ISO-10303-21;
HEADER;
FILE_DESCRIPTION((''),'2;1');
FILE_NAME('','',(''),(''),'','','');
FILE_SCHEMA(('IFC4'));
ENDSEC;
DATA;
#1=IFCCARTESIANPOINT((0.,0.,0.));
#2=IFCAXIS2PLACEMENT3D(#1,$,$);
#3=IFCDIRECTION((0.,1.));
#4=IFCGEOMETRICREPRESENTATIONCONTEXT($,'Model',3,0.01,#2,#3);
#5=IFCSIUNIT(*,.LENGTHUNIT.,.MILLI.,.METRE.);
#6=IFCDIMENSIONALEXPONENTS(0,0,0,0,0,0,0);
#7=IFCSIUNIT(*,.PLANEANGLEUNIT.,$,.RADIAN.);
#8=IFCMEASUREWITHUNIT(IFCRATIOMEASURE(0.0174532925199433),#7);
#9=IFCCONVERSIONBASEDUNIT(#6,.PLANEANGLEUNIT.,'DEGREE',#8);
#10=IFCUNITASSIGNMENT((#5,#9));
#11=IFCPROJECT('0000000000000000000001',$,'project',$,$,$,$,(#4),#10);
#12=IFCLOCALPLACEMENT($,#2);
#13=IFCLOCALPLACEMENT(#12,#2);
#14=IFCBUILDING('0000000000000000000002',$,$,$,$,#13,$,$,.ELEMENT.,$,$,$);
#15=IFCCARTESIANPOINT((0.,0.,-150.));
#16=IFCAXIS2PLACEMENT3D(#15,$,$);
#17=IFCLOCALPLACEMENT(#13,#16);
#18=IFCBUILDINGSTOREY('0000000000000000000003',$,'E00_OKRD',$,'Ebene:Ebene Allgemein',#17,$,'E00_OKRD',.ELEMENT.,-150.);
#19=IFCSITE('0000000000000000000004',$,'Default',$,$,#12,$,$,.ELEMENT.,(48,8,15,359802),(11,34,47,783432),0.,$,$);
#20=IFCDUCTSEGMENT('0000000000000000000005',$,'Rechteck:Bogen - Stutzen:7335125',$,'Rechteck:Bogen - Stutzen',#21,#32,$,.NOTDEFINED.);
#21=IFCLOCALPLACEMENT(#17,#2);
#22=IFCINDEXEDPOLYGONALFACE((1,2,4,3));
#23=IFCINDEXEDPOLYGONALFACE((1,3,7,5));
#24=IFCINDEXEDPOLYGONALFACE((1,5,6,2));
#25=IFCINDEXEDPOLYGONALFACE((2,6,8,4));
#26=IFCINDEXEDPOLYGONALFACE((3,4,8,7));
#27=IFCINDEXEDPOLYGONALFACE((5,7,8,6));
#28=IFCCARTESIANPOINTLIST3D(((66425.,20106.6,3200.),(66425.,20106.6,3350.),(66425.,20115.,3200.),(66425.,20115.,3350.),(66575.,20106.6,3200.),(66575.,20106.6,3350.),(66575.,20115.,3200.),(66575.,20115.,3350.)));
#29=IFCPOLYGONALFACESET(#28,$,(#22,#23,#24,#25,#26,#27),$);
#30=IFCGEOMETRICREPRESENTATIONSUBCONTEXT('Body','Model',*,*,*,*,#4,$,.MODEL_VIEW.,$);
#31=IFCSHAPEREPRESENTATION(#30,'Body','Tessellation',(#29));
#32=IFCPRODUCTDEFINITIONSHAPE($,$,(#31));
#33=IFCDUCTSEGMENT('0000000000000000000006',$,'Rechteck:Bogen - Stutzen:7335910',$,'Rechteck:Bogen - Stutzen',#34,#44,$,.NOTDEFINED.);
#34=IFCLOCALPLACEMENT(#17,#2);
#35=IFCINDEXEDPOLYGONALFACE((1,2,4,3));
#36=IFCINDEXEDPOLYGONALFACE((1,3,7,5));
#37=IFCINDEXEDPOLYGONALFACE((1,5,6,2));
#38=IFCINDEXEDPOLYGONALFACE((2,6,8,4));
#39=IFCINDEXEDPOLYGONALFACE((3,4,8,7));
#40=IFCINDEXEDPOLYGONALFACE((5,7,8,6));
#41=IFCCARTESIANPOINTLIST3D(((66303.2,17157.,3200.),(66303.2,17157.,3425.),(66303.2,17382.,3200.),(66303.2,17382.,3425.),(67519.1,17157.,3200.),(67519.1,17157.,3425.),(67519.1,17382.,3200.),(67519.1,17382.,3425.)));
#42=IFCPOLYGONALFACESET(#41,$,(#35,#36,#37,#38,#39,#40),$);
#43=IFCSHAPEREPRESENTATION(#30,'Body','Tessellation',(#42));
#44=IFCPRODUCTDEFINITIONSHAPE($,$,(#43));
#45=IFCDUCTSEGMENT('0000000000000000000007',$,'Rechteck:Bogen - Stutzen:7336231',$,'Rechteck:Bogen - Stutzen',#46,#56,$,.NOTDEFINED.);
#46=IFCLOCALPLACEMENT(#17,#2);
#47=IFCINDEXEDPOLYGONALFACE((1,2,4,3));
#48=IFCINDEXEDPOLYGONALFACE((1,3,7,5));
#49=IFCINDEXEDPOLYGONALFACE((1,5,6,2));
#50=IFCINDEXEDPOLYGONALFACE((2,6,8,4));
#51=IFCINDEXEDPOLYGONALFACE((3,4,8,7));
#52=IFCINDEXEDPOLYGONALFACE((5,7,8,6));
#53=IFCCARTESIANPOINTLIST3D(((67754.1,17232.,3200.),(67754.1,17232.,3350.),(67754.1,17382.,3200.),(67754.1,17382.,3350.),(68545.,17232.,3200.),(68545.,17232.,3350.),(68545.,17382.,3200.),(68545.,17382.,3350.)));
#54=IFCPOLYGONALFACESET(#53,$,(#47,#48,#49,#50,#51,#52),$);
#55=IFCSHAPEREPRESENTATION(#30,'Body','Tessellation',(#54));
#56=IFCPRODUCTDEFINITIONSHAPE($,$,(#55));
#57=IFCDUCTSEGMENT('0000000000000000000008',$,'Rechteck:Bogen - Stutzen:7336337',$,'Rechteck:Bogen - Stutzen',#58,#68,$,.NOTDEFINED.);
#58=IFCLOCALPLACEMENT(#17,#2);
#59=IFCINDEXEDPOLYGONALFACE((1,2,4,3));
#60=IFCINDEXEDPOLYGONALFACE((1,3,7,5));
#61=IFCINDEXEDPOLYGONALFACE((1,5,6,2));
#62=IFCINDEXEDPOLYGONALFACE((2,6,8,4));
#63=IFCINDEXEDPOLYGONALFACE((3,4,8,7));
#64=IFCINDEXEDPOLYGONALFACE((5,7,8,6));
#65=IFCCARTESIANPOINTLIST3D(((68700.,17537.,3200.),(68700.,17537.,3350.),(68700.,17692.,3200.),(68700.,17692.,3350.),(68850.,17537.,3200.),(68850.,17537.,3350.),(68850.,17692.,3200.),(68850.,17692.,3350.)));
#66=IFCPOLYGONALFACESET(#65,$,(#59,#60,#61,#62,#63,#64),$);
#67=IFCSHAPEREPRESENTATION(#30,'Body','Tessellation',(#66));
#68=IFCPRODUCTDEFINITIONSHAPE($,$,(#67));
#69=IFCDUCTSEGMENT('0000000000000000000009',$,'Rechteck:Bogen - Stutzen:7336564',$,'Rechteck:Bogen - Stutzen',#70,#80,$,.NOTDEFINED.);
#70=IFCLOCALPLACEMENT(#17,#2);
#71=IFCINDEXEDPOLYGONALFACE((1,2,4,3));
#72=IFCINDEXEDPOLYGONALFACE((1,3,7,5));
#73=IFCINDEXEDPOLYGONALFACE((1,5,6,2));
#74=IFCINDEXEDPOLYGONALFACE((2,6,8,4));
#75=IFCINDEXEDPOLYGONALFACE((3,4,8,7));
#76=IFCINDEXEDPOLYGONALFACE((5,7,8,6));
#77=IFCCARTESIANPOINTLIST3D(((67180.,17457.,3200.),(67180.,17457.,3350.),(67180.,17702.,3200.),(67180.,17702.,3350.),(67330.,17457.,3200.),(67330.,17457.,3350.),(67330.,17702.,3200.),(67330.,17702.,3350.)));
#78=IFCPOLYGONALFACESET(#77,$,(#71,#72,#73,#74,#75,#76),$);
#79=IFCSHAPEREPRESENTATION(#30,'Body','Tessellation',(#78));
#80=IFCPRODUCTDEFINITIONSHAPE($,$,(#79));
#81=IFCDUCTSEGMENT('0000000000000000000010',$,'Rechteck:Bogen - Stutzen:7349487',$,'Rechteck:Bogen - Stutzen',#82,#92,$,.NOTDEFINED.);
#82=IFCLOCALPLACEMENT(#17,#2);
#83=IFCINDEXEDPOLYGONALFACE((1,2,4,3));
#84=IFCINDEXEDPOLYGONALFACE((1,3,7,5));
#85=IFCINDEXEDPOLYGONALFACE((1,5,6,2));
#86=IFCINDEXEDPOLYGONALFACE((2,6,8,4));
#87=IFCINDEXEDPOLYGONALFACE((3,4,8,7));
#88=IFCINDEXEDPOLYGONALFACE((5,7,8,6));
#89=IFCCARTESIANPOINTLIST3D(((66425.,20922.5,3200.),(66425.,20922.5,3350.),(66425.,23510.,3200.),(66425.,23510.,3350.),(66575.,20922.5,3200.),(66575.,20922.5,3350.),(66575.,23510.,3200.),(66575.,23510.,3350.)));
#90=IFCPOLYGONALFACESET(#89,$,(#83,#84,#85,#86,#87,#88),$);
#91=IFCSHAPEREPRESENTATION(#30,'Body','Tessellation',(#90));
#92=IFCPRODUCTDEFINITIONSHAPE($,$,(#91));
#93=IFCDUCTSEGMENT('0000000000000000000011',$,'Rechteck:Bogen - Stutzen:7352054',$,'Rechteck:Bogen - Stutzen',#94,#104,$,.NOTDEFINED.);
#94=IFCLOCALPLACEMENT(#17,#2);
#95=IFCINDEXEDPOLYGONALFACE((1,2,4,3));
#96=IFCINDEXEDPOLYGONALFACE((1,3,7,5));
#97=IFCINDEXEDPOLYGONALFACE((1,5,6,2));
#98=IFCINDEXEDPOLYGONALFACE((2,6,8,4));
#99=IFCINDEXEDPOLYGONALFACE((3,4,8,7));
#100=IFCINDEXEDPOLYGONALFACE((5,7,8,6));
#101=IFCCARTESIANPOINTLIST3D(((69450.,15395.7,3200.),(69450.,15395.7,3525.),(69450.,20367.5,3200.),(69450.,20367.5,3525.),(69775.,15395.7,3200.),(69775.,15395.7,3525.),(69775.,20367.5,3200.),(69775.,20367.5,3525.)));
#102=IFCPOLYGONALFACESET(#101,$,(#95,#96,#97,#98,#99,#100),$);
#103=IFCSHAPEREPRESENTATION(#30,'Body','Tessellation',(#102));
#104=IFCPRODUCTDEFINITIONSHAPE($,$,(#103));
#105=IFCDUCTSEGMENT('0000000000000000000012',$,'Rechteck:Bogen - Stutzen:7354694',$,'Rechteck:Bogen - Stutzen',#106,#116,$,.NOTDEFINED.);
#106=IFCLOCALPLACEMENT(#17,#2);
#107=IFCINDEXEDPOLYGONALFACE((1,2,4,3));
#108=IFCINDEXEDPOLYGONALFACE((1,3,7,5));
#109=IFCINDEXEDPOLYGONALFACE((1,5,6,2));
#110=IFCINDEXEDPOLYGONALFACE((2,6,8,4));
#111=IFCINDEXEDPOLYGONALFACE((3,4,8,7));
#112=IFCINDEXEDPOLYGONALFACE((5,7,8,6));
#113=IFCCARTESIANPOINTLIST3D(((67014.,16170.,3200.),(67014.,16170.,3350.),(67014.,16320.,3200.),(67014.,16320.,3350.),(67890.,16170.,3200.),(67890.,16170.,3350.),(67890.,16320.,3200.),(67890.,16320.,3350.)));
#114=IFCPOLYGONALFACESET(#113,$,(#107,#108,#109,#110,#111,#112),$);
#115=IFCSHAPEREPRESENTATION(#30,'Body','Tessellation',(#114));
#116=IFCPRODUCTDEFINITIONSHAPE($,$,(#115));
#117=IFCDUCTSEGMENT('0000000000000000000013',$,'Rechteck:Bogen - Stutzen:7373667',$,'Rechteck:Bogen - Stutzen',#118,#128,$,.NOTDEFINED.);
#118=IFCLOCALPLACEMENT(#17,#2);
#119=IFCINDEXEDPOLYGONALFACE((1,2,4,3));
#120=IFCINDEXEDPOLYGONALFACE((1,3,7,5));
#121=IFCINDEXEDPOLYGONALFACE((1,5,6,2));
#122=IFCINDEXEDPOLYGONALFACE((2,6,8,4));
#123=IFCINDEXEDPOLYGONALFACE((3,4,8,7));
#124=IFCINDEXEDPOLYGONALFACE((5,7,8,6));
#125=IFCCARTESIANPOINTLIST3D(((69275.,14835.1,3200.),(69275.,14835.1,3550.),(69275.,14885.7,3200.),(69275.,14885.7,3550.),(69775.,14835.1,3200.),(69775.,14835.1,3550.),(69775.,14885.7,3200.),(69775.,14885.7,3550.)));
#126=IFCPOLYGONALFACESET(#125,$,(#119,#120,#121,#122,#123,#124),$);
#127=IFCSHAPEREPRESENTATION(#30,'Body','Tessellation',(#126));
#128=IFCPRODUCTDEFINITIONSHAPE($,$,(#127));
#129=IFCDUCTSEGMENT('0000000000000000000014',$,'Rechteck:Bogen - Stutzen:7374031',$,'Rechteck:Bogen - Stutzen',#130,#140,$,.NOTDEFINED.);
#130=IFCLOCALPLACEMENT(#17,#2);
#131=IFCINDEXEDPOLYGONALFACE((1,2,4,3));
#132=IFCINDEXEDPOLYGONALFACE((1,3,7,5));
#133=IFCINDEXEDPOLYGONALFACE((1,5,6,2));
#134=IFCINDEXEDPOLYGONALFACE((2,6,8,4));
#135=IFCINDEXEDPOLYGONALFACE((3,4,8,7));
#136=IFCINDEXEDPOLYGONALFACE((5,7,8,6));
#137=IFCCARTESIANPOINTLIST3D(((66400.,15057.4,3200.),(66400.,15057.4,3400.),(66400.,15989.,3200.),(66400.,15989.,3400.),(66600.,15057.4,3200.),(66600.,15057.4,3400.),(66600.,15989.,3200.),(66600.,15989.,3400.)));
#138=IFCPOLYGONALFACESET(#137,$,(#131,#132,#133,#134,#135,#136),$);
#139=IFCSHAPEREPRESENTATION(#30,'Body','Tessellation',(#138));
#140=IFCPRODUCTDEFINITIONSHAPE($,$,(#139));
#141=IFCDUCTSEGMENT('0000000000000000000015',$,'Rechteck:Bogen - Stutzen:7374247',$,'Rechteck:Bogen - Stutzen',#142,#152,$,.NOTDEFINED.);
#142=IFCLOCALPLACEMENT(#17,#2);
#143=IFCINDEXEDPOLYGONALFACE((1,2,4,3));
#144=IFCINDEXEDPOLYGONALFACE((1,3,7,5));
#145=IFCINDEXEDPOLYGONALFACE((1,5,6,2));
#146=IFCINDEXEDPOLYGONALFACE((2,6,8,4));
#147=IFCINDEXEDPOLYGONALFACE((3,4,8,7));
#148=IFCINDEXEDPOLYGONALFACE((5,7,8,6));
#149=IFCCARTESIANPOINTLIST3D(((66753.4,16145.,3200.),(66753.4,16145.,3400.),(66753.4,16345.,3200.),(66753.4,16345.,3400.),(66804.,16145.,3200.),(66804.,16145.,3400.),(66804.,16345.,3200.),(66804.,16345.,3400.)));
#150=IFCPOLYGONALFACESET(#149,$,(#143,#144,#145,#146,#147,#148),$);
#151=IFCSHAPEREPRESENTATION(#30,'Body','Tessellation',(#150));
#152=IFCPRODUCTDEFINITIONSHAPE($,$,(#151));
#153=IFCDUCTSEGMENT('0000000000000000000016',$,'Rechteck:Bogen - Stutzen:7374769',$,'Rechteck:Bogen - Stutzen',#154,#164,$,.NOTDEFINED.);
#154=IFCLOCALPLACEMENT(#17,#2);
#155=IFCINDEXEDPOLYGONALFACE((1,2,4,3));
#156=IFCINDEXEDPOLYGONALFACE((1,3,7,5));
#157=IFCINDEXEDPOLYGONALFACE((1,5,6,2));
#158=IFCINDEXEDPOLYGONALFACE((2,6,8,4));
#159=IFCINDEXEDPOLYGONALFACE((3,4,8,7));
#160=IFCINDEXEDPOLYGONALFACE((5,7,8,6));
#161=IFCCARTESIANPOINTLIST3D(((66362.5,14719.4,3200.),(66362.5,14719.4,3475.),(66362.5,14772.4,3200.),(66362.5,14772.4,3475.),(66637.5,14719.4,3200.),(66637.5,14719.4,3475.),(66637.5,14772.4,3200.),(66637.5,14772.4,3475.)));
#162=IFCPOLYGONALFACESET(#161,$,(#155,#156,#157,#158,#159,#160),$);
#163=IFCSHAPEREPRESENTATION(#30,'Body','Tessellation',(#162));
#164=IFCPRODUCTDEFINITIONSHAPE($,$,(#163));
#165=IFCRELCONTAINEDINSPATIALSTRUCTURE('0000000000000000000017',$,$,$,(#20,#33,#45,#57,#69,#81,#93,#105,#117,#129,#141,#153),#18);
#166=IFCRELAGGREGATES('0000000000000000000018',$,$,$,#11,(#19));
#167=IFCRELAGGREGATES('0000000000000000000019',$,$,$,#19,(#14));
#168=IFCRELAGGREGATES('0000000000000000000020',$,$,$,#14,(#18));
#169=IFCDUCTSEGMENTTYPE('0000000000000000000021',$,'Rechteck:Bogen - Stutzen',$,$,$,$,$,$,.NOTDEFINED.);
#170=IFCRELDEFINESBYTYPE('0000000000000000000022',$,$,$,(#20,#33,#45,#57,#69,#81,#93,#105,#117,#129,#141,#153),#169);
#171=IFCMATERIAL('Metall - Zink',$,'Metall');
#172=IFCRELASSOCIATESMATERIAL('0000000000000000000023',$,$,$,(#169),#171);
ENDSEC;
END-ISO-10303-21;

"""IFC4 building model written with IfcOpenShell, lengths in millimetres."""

from ifc_helpers import new_model, entity, si_unit, converted_unit, direction, frame, frame_2d, origin, origin_2d_with_axis, place, context, subcontext, project, spatial, rectangle, extrude, material, type_object, element, save


model = new_model("IFC4")

# Units and contexts
model_context = context("Model", 3, precision=0.01, world=origin(), true_north=direction((0.0, 1.0)))
body_context = subcontext(model_context, "Body", "Model", "MODEL_VIEW")
ifc_project = project(units=[si_unit("LENGTHUNIT", "METRE", prefix="MILLI"), converted_unit("PLANEANGLEUNIT", "DEGREE", entity("IfcRatioMeasure", 0.0174532925199433), si_unit("PLANEANGLEUNIT", "RADIAN"), dimensions=[0, 0, 0, 0, 0, 0, 0])], contexts=[model_context])

# Site, building, storey
site_placement = place(None, origin())
site = spatial("IfcSite", under=ifc_project, at=site_placement, Name="Default", CompositionType="ELEMENT", RefLatitude=(48, 8, 15, 359802), RefLongitude=(11, 34, 47, 783432), RefElevation=0.0)
building_placement = place(site_placement, origin())
building = spatial("IfcBuilding", under=site, at=building_placement, CompositionType="ELEMENT")
storey_placement = place(building_placement, frame((0.0, 0.0, -150.0)))
storey = spatial("IfcBuildingStorey", under=building, at=storey_placement, Name="E00_OKRD", ObjectType="Ebene:Ebene Allgemein", LongName="E00_OKRD", CompositionType="ELEMENT", Elevation=-150.0)

# Duct segments
ifc_material_1 = material(Name="Metall - Zink", Category="Metall")
duct_segment_type_1 = type_object("IfcDuctSegmentType", Name="Rechteck:Bogen - Stutzen", PredefinedType="NOTDEFINED", material=ifc_material_1)
duct_segment_1_placement = place(storey_placement, frame((66425.0, 20106.6, 3200.0)))
element("IfcDuctSegment", 1, at=duct_segment_1_placement, inside=storey, type_object=duct_segment_type_1, Name="Rechteck:Bogen - Stutzen:7335125", ObjectType="Rechteck:Bogen - Stutzen", PredefinedType="NOTDEFINED", context=body_context, shape_type="SweptSolid", body=[
    extrude(rectangle(XDim=8.4, YDim=150.0, at=frame_2d((0.0, 0.0), x_axis=(1.0, 0.0))), frame((75.0, 4.2, 0.0), z_axis=(0.0, 0.0, 1.0), x_axis=(0.0, -1.0, 0.0)), (0.0, 0.0, 1.0), 150.0),
])
duct_segment_2_placement = place(storey_placement, frame((66303.2, 17157.0, 3200.0)))
element("IfcDuctSegment", 2, at=duct_segment_2_placement, inside=storey, type_object=duct_segment_type_1, Name="Rechteck:Bogen - Stutzen:7335910", ObjectType="Rechteck:Bogen - Stutzen", PredefinedType="NOTDEFINED", context=body_context, shape_type="SweptSolid", body=[
    extrude(rectangle(XDim=1215.9, YDim=225.0, at=frame_2d((0.0, 0.0), x_axis=(1.0, 0.0))), frame((607.9, 112.5, 0.0)), (0.0, 0.0, 1.0), 225.0),
])
duct_segment_3_placement = place(storey_placement, frame((67754.1, 17232.0, 3200.0)))
element("IfcDuctSegment", 3, at=duct_segment_3_placement, inside=storey, type_object=duct_segment_type_1, Name="Rechteck:Bogen - Stutzen:7336231", ObjectType="Rechteck:Bogen - Stutzen", PredefinedType="NOTDEFINED", context=body_context, shape_type="SweptSolid", body=[
    extrude(rectangle(XDim=790.8, YDim=150.0, at=frame_2d((0.0, 0.0), x_axis=(1.0, 0.0))), frame((395.4, 75.0, 0.0), z_axis=(0.0, 0.0, 1.0), x_axis=(-1.0, 0.0, 0.0)), (0.0, 0.0, 1.0), 150.0),
])
duct_segment_4_placement = place(storey_placement, frame((68700.0, 17537.0, 3200.0)))
element("IfcDuctSegment", 4, at=duct_segment_4_placement, inside=storey, type_object=duct_segment_type_1, Name="Rechteck:Bogen - Stutzen:7336337", ObjectType="Rechteck:Bogen - Stutzen", PredefinedType="NOTDEFINED", context=body_context, shape_type="SweptSolid", body=[
    extrude(rectangle(XDim=155.0, YDim=150.0, at=frame_2d((0.0, 0.0), x_axis=(1.0, 0.0))), frame((75.0, 77.5, 0.0), z_axis=(0.0, 0.0, 1.0), x_axis=(0.0, 1.0, 0.0)), (0.0, 0.0, 1.0), 150.0),
])
duct_segment_5_placement = place(storey_placement, frame((67180.0, 17457.0, 3200.0)))
element("IfcDuctSegment", 5, at=duct_segment_5_placement, inside=storey, type_object=duct_segment_type_1, Name="Rechteck:Bogen - Stutzen:7336564", ObjectType="Rechteck:Bogen - Stutzen", PredefinedType="NOTDEFINED", context=body_context, shape_type="SweptSolid", body=[
    extrude(rectangle(XDim=245.0, YDim=150.0, at=origin_2d_with_axis()), frame((75.0, 122.5, 0.0), z_axis=(0.0, 0.0, 1.0), x_axis=(0.0, 1.0, 0.0)), (0.0, 0.0, 1.0), 150.0),
])
duct_segment_6_placement = place(storey_placement, frame((66425.0, 20922.5, 3200.0)))
element("IfcDuctSegment", 6, at=duct_segment_6_placement, inside=storey, type_object=duct_segment_type_1, Name="Rechteck:Bogen - Stutzen:7349487", ObjectType="Rechteck:Bogen - Stutzen", PredefinedType="NOTDEFINED", context=body_context, shape_type="SweptSolid", body=[
    extrude(rectangle(XDim=2587.5, YDim=150.0, at=origin_2d_with_axis()), frame((75.0, 1293.7, 0.0), z_axis=(0.0, 0.0, 1.0), x_axis=(0.0, 1.0, 0.0)), (0.0, 0.0, 1.0), 150.0),
])
duct_segment_7_placement = place(storey_placement, frame((69450.0, 15395.7, 3200.0)))
element("IfcDuctSegment", 7, at=duct_segment_7_placement, inside=storey, type_object=duct_segment_type_1, Name="Rechteck:Bogen - Stutzen:7352054", ObjectType="Rechteck:Bogen - Stutzen", PredefinedType="NOTDEFINED", context=body_context, shape_type="SweptSolid", body=[
    extrude(rectangle(XDim=4971.8, YDim=325.0, at=frame_2d((0.0, 0.0), x_axis=(1.0, 0.0))), frame((162.5, 2485.9, 0.0), z_axis=(0.0, 0.0, 1.0), x_axis=(0.0, -1.0, 0.0)), (0.0, 0.0, 1.0), 325.0),
])
duct_segment_8_placement = place(storey_placement, frame((67014.0, 16170.0, 3200.0)))
element("IfcDuctSegment", 8, at=duct_segment_8_placement, inside=storey, type_object=duct_segment_type_1, Name="Rechteck:Bogen - Stutzen:7354694", ObjectType="Rechteck:Bogen - Stutzen", PredefinedType="NOTDEFINED", context=body_context, shape_type="SweptSolid", body=[
    extrude(rectangle(XDim=875.9, YDim=150.0, at=origin_2d_with_axis()), frame((438.0, 75.0, 0.0), z_axis=(0.0, 0.0, 1.0), x_axis=(-1.0, 0.0, 0.0)), (0.0, 0.0, 1.0), 150.0),
])
duct_segment_9_placement = place(storey_placement, frame((69275.0, 14835.1, 3200.0)))
element("IfcDuctSegment", 9, at=duct_segment_9_placement, inside=storey, type_object=duct_segment_type_1, Name="Rechteck:Bogen - Stutzen:7373667", ObjectType="Rechteck:Bogen - Stutzen", PredefinedType="NOTDEFINED", context=body_context, shape_type="SweptSolid", body=[
    extrude(rectangle(XDim=50.6, YDim=500.0, at=frame_2d((0.0, 0.0), x_axis=(1.0, 0.0))), frame((250.0, 25.3, 0.0), z_axis=(0.0, 0.0, 1.0), x_axis=(0.0, 1.0, 0.0)), (0.0, 0.0, 1.0), 350.0),
])
duct_segment_10_placement = place(storey_placement, frame((66400.0, 15057.4, 3200.0)))
element("IfcDuctSegment", 10, at=duct_segment_10_placement, inside=storey, type_object=duct_segment_type_1, Name="Rechteck:Bogen - Stutzen:7374031", ObjectType="Rechteck:Bogen - Stutzen", PredefinedType="NOTDEFINED", context=body_context, shape_type="SweptSolid", body=[
    extrude(rectangle(XDim=931.5, YDim=200.0, at=frame_2d((0.0, 0.0), x_axis=(1.0, 0.0))), frame((100.0, 465.8, 0.0), z_axis=(0.0, 0.0, 1.0), x_axis=(0.0, -1.0, 0.0)), (0.0, 0.0, 1.0), 200.0),
])
duct_segment_11_placement = place(storey_placement, frame((66753.4, 16145.0, 3200.0)))
element("IfcDuctSegment", 11, at=duct_segment_11_placement, inside=storey, type_object=duct_segment_type_1, Name="Rechteck:Bogen - Stutzen:7374247", ObjectType="Rechteck:Bogen - Stutzen", PredefinedType="NOTDEFINED", context=body_context, shape_type="SweptSolid", body=[
    extrude(rectangle(XDim=50.7, YDim=200.0, at=frame_2d((0.0, 0.0), x_axis=(1.0, 0.0))), frame((25.3, 100.0, 0.0)), (0.0, 0.0, 1.0), 200.0),
])
duct_segment_12_placement = place(storey_placement, frame((66362.5, 14719.4, 3200.0)))
element("IfcDuctSegment", 12, at=duct_segment_12_placement, inside=storey, type_object=duct_segment_type_1, Name="Rechteck:Bogen - Stutzen:7374769", ObjectType="Rechteck:Bogen - Stutzen", PredefinedType="NOTDEFINED", context=body_context, shape_type="SweptSolid", body=[
    extrude(rectangle(XDim=53.1, YDim=275.0, at=frame_2d((0.0, 0.0), x_axis=(1.0, 0.0))), frame((137.5, 26.5, 0.0), z_axis=(0.0, 0.0, 1.0), x_axis=(0.0, 1.0, 0.0)), (0.0, 0.0, 1.0), 275.0),
])

save(model, "model.ifc")
